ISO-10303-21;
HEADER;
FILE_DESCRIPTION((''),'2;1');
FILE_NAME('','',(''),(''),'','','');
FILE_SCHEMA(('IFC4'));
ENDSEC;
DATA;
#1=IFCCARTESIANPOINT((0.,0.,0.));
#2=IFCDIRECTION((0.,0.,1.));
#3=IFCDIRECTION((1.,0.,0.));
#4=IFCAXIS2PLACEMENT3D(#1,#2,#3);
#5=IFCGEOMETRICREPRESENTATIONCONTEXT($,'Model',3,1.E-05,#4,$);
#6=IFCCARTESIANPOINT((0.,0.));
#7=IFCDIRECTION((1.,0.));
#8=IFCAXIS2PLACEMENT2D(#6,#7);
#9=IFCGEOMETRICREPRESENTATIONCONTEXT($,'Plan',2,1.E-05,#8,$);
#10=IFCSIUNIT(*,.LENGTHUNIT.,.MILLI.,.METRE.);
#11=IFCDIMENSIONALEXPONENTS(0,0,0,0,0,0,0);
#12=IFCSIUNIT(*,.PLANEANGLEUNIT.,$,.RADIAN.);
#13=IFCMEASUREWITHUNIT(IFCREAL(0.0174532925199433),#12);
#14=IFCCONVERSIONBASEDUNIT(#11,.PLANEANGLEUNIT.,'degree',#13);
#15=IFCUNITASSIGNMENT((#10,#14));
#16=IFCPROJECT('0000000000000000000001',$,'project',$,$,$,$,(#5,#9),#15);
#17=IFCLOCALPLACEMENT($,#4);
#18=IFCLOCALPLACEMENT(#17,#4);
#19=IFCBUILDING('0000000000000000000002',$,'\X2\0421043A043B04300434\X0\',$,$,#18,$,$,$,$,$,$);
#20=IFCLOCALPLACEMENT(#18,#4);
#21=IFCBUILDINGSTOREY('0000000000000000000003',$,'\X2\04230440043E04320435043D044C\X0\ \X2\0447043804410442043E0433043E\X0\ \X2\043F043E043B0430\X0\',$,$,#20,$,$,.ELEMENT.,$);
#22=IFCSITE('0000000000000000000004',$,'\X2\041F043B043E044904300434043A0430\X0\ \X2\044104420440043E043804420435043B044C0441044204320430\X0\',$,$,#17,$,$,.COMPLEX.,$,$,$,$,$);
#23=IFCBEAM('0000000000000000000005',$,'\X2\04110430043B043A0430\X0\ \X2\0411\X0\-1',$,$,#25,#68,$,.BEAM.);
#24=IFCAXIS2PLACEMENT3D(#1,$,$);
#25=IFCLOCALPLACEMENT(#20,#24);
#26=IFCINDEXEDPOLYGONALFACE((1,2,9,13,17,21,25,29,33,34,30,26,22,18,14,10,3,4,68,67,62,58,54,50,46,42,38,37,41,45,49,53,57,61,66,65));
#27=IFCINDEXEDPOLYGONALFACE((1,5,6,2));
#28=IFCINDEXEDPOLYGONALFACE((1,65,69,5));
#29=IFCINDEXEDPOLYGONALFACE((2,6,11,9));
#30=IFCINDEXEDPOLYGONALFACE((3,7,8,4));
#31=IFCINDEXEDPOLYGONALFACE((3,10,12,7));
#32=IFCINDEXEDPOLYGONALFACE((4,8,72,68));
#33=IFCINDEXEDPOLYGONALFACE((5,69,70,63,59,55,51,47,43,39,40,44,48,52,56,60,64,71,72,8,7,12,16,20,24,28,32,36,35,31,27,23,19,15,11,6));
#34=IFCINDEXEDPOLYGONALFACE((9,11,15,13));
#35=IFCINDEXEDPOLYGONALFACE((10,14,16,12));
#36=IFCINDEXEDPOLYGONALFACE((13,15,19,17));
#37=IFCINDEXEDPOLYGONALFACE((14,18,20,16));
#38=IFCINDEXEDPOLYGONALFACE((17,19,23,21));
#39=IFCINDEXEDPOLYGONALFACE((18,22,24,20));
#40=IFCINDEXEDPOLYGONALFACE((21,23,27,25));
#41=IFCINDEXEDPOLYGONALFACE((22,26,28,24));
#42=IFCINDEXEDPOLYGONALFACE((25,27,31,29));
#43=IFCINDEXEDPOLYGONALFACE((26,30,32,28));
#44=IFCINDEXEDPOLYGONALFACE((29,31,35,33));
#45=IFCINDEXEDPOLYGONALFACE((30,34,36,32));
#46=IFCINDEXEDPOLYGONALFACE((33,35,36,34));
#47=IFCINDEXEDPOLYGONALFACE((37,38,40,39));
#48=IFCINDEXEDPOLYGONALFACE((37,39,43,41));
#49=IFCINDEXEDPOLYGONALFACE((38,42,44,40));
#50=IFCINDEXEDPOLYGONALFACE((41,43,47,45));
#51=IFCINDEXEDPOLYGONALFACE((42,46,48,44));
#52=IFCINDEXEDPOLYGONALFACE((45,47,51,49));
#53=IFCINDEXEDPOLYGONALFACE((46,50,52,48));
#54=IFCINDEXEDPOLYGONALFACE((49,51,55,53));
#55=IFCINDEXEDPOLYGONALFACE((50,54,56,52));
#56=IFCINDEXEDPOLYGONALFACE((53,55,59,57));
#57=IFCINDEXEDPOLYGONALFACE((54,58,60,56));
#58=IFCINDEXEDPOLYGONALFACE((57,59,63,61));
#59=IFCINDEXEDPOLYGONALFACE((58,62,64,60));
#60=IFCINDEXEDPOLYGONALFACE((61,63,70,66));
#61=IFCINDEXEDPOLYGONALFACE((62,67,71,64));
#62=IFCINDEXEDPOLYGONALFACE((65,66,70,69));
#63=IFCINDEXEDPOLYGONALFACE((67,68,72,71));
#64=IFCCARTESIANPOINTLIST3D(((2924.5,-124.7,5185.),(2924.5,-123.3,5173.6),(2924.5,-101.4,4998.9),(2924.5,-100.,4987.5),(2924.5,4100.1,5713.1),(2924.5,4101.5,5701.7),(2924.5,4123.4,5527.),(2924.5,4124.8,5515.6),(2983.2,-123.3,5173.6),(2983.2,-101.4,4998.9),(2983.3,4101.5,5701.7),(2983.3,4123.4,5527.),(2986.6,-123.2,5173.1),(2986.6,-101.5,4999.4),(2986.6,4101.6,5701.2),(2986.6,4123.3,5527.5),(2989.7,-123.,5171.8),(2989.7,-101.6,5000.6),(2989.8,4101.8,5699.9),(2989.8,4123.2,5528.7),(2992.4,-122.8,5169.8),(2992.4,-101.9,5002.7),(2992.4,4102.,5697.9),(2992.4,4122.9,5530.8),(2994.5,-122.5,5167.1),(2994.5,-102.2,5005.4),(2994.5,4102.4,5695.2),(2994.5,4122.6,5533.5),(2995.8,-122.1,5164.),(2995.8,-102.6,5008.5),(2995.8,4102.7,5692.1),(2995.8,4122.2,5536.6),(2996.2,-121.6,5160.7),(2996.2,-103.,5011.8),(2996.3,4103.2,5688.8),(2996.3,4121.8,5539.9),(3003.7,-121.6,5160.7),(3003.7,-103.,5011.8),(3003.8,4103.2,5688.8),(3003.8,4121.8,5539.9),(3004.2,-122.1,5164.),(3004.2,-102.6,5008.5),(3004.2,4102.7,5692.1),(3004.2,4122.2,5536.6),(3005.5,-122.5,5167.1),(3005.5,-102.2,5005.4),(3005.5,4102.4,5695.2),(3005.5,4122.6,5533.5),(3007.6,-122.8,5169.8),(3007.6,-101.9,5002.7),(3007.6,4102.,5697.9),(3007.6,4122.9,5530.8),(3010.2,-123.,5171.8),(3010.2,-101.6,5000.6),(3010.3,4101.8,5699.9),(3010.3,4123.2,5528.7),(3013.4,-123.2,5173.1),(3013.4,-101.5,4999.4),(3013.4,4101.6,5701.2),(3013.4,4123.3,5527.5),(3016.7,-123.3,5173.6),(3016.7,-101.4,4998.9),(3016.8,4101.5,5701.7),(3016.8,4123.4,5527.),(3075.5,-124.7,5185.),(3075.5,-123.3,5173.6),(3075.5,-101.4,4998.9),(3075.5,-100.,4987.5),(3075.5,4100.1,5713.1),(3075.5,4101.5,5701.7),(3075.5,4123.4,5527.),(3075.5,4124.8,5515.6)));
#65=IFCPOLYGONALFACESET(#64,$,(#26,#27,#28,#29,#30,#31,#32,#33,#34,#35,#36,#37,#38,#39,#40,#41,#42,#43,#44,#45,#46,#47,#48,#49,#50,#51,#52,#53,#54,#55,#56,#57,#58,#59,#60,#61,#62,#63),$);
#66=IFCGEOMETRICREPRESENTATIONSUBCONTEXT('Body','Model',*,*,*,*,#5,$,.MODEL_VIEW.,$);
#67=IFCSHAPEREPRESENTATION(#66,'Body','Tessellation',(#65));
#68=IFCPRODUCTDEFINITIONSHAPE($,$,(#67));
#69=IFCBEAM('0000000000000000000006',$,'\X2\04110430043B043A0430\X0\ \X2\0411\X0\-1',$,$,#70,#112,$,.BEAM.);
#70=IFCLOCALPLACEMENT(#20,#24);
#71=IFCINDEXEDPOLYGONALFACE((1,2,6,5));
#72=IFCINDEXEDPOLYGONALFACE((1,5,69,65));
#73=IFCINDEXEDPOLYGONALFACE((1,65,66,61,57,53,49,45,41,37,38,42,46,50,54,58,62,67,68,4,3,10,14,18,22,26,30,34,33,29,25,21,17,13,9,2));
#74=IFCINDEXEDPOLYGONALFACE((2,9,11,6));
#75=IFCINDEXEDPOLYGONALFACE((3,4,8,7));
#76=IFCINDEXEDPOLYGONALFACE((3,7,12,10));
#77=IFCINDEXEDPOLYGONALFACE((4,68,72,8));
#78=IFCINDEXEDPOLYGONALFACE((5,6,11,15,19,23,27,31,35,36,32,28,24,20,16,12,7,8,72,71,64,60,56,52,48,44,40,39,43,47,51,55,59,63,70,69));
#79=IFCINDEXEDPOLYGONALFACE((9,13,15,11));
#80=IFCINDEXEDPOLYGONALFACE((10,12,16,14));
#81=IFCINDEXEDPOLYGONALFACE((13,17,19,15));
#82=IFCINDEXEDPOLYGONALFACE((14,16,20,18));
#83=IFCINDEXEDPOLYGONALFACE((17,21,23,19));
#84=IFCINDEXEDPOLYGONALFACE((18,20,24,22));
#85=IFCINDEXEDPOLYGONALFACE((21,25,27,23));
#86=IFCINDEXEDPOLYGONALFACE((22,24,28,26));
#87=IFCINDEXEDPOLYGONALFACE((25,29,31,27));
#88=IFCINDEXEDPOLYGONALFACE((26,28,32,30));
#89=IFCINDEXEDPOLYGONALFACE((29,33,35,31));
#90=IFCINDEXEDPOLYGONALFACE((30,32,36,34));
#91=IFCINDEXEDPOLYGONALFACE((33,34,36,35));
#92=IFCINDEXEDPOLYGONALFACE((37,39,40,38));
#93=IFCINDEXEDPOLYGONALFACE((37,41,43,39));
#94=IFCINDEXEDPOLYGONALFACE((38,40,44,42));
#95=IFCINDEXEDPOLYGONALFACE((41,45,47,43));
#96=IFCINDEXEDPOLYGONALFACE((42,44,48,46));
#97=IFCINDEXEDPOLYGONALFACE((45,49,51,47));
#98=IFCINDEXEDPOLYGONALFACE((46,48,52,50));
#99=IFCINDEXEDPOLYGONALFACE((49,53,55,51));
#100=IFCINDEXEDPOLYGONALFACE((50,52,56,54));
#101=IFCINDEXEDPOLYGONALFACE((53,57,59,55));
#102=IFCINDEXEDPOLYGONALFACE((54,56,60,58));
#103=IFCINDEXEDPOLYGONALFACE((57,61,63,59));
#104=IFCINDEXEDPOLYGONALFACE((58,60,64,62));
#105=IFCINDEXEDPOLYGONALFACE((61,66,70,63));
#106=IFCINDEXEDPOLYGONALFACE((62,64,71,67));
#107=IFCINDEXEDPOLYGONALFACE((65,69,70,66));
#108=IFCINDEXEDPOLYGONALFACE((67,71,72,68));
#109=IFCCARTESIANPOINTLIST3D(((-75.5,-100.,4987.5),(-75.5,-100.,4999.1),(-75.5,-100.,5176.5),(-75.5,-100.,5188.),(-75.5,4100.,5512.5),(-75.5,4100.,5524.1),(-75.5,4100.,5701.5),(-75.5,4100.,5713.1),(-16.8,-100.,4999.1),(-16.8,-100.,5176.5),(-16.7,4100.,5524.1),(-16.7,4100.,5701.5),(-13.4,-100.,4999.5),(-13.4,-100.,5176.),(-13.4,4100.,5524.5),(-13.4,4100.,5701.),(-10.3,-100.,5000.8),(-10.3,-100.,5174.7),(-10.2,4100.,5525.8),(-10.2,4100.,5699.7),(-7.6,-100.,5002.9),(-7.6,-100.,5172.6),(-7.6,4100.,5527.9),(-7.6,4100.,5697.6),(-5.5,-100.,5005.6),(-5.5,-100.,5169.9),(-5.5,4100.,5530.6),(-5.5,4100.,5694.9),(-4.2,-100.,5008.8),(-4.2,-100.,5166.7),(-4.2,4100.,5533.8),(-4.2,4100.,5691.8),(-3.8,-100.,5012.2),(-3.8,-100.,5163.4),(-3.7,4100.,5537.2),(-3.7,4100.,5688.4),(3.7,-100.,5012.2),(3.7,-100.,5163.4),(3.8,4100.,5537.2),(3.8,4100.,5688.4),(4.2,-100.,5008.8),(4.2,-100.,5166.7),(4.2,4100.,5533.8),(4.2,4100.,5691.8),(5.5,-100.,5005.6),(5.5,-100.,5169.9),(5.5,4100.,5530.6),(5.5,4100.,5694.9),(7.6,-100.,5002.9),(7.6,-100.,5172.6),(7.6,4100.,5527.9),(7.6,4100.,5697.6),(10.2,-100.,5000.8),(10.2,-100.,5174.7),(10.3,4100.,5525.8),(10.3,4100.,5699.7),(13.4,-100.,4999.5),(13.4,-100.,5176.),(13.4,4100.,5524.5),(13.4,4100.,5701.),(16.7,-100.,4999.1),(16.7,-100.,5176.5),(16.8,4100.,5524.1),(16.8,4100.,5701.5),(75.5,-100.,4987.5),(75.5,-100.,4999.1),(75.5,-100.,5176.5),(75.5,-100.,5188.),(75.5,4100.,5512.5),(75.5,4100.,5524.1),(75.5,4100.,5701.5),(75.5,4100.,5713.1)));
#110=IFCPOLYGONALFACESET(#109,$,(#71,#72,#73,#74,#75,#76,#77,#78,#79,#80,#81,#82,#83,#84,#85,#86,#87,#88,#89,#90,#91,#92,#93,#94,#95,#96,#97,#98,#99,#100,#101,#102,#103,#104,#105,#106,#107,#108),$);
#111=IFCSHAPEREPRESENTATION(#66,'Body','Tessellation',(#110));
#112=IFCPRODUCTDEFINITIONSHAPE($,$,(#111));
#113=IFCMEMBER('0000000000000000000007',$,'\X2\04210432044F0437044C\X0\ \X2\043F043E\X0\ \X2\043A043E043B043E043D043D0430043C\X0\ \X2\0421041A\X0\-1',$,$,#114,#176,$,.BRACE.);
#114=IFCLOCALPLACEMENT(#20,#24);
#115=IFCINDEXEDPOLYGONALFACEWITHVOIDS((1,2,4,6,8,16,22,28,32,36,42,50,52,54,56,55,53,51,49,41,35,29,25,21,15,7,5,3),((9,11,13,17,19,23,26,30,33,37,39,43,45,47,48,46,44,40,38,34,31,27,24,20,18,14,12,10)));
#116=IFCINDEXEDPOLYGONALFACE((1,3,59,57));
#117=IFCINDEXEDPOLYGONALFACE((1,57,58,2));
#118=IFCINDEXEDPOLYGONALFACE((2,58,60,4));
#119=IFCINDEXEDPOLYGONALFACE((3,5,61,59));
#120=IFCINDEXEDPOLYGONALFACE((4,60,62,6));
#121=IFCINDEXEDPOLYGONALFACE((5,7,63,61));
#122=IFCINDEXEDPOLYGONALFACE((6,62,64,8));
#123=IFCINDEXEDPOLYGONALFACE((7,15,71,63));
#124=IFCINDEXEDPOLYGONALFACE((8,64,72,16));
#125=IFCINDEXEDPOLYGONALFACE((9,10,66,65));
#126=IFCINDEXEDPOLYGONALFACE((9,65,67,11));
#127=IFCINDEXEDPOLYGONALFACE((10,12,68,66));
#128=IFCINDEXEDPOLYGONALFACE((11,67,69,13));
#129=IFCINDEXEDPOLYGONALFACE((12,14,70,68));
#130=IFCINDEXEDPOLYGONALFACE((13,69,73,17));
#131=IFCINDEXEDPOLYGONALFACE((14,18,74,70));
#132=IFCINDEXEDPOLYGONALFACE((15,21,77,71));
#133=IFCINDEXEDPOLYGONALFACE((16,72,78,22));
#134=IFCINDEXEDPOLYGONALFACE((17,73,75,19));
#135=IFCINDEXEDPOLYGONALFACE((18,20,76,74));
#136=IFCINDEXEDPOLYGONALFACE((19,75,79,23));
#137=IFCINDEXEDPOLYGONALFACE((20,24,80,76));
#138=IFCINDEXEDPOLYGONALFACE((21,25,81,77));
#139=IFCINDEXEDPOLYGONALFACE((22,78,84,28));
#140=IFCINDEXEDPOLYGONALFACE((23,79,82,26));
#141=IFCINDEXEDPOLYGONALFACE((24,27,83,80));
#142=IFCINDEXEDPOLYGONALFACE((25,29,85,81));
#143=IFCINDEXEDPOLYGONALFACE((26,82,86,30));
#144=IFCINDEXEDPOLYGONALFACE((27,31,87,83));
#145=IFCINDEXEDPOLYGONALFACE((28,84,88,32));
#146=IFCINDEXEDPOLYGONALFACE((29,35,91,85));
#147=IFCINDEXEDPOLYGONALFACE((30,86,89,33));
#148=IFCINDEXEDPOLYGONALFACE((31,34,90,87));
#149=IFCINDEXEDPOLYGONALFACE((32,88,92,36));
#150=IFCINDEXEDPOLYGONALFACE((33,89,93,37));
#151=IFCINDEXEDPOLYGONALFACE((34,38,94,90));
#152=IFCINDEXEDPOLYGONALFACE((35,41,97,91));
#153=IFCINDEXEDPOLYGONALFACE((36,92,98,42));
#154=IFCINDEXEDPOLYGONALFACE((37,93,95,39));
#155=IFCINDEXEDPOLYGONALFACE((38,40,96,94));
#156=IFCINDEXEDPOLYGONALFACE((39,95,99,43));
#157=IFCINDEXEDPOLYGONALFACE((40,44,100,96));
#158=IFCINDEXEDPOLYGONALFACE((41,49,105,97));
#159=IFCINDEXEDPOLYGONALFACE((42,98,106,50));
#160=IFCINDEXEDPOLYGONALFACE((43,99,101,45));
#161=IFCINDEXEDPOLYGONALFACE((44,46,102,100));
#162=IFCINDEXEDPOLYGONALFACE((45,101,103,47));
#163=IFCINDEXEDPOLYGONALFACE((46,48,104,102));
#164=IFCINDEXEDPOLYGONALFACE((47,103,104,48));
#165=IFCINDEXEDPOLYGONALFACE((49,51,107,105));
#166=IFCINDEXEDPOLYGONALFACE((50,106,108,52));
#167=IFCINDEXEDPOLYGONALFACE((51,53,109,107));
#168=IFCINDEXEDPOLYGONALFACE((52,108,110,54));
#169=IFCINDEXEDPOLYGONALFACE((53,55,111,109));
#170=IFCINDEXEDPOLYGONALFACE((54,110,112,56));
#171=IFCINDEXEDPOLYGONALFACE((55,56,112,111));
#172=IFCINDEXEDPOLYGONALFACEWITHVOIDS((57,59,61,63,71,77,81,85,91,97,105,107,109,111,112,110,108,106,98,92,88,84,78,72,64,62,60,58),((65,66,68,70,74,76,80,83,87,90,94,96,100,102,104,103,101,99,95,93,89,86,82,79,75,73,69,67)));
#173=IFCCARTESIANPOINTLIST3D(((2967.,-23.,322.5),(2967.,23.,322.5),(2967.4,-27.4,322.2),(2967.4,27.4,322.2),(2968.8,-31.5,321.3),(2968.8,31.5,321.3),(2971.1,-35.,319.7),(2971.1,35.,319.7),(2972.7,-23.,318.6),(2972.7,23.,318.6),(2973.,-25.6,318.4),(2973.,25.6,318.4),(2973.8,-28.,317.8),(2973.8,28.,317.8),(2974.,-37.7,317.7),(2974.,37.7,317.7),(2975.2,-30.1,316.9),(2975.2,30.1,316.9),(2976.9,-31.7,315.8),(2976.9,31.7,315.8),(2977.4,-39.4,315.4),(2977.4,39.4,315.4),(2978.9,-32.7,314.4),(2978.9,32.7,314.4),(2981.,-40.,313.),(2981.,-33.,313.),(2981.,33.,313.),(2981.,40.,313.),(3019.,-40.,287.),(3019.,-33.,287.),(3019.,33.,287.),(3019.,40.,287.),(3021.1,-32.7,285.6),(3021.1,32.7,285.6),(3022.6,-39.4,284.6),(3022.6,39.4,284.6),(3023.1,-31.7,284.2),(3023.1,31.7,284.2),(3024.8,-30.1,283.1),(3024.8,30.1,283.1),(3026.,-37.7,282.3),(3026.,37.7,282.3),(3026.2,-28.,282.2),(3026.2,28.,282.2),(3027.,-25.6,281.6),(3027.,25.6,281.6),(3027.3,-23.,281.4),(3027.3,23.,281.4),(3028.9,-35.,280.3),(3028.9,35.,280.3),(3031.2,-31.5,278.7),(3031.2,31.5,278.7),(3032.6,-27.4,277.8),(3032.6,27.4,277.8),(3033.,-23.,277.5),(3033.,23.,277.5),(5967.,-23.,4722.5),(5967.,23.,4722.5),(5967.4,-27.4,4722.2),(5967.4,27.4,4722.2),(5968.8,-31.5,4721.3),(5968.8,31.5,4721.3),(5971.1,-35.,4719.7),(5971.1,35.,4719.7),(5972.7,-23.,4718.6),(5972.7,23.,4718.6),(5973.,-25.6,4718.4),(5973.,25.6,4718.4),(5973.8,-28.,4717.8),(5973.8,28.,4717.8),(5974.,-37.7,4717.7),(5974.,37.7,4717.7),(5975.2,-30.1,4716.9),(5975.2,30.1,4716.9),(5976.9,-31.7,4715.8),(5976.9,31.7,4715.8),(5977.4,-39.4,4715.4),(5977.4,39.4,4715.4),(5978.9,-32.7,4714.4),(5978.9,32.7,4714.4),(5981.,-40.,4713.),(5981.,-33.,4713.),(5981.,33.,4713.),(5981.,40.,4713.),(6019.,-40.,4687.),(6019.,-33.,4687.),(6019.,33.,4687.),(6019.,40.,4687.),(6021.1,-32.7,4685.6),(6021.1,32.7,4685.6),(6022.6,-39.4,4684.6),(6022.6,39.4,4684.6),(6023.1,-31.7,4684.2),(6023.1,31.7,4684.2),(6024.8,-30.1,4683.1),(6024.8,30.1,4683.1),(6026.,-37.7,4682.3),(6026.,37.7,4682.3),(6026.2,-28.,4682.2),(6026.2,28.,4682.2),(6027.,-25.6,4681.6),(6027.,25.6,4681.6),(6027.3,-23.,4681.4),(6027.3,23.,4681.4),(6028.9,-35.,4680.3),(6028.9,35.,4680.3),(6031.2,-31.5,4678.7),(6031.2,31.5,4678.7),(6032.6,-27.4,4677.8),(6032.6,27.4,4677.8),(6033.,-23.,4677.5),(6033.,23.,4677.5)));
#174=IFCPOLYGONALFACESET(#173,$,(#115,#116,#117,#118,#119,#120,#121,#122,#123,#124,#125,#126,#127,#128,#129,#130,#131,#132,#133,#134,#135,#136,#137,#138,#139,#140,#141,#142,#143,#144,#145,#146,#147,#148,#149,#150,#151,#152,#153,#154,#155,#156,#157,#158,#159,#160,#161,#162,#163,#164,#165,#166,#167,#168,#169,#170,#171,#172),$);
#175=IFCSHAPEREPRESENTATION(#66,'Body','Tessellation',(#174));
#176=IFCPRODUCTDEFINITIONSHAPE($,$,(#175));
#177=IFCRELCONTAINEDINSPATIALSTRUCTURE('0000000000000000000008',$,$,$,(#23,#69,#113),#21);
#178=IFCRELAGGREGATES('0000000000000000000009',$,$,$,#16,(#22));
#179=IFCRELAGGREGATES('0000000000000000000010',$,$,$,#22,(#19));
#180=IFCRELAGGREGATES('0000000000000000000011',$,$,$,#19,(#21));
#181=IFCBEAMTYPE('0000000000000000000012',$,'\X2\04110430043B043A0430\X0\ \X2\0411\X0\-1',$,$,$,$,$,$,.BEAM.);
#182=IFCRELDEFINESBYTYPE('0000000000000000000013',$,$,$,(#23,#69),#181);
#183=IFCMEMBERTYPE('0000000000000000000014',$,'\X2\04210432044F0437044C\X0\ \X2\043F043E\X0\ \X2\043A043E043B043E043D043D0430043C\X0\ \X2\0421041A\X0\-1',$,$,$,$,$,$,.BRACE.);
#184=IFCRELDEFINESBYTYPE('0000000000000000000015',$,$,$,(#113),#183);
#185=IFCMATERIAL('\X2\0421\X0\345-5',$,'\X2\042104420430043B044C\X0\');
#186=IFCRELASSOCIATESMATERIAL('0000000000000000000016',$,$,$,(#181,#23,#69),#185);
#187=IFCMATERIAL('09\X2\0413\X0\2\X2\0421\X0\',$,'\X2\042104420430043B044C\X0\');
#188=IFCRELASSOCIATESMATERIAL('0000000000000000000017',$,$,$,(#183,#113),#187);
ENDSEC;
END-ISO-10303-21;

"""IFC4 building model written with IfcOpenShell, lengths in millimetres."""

from ifc_helpers import new_model, entity, si_unit, converted_unit, frame, origin_with_axes, origin_2d_with_axis, place, context, subcontext, project, spatial, hollow_rectangle, i_section, extrude, clip, halfspace, material, material_profile, profile_set, profile_usage, type_object, element, save


model = new_model("IFC4")

# Units and contexts
model_context = context("Model", 3, precision=1e-05, world=origin_with_axes())
plan_context = context("Plan", 2, precision=1e-05, world=origin_2d_with_axis())
body_context = subcontext(model_context, "Body", "Model", "MODEL_VIEW")
ifc_project = project(units=[si_unit("LENGTHUNIT", "METRE", prefix="MILLI"), converted_unit("PLANEANGLEUNIT", "degree", entity("IfcReal", 0.0174532925199433), si_unit("PLANEANGLEUNIT", "RADIAN"), dimensions=[0, 0, 0, 0, 0, 0, 0])], contexts=[model_context, plan_context])

# Site, building, storey
site_placement = place(None, origin_with_axes())
site = spatial("IfcSite", under=ifc_project, at=site_placement, Name="Площадка строительства", CompositionType="COMPLEX")
building_placement = place(site_placement, origin_with_axes())
building = spatial("IfcBuilding", under=site, at=building_placement, Name="Склад")
storey_placement = place(building_placement, origin_with_axes())
storey = spatial("IfcBuildingStorey", under=building, at=storey_placement, Name="Уровень чистого пола", CompositionType="ELEMENT")

# Shared definitions
ifc_material_1 = material(Name="С345-5", Category="Сталь")

# Beams
ifc_material_profile_1 = material_profile(ifc_material_1, i_section(OverallWidth=151.0, OverallDepth=199.0, WebThickness=7.5, FlangeThickness=11.5, FilletRadius=13.0, FlangeEdgeRadius=0.0, FlangeSlope=0.0))
ifc_profile_set_1 = profile_set([ifc_material_profile_1], Name="I20H2_S345-5")
ifc_profile_usage_1 = profile_usage(ifc_profile_set_1, cardinal=2)
beam_type_1 = type_object("IfcBeamType", Name="Балка Б-1", PredefinedType="BEAM", material=ifc_profile_set_1)
beam_1_placement = place(storey_placement, frame((3000.0, -100.0, 4987.5), z_axis=(0.0, 0.992278, 0.124035), x_axis=(-1.0, 0.0, 0.0)))
element("IfcBeam", 1, at=beam_1_placement, inside=storey, type_object=beam_type_1, material=ifc_profile_usage_1, Name="Балка Б-1", PredefinedType="BEAM", context=body_context, shape_type="SweptSolid", body=[
    extrude(i_section(OverallWidth=151.0, OverallDepth=199.0, WebThickness=7.5, FlangeThickness=11.5, FilletRadius=13.0, FlangeEdgeRadius=0.0, FlangeSlope=0.0), frame((0.0, 99.5, 0.0), z_axis=(0.0, 0.0, 1.0), x_axis=(1.0, 0.0, 0.0)), (0.0, 0.0, 1.0), 4257.7),
])
beam_2_placement = place(storey_placement, frame((0.0, -298.5, 4962.7), z_axis=(0.0, 0.992278, 0.124035), x_axis=(-1.0, 0.0, 0.0)))
element("IfcBeam", 2, at=beam_2_placement, inside=storey, type_object=beam_type_1, material=ifc_profile_usage_1, Name="Балка Б-1", PredefinedType="BEAM", context=body_context, shape_type="Clipping", body=[
    clip(clip(extrude(i_section(OverallWidth=151.0, OverallDepth=199.0, WebThickness=7.5, FlangeThickness=11.5, FilletRadius=13.0, FlangeEdgeRadius=0.0, FlangeSlope=0.0), frame((0.0, 99.5, 0.0), z_axis=(0.0, 0.0, 1.0), x_axis=(1.0, 0.0, 0.0)), (0.0, 0.0, 1.0), 4632.7), halfspace(frame((0.0, -5469.9, 3748.9), z_axis=(0.0, -0.124035, 0.992278), x_axis=(0.0, 0.992278, 0.124035)), False)), halfspace(frame((0.0, -4949.0, -418.6), z_axis=(0.0, 0.124035, -0.992278), x_axis=(0.0, 0.992278, 0.124035)), False)),
])

# Member
ifc_material_2 = material(Name="09Г2С", Category="Сталь")
ifc_material_profile_2 = material_profile(ifc_material_2, hollow_rectangle(XDim=80.0, YDim=80.0, WallThickness=7.0, InnerFilletRadius=10.0, OuterFilletRadius=17.0))
ifc_profile_set_2 = profile_set([ifc_material_profile_2], Name="PK80x7_09G2S")
ifc_profile_usage_2 = profile_usage(ifc_profile_set_2, cardinal=5)
member_type_1 = type_object("IfcMemberType", Name="Связь по колоннам СК-1", PredefinedType="BRACE", material=ifc_profile_set_2)
member_1_placement = place(storey_placement, frame((3000.0, 0.0, 300.0), z_axis=(0.563337, 0.0, 0.826227), x_axis=(0.0, 1.0, 0.0)))
element("IfcMember", 3, at=member_1_placement, inside=storey, type_object=member_type_1, material=ifc_profile_usage_2, Name="Связь по колоннам СК-1", PredefinedType="BRACE", context=body_context, shape_type="Clipping", body=[
    extrude(hollow_rectangle(XDim=80.0, YDim=80.0, WallThickness=7.0, InnerFilletRadius=10.0, OuterFilletRadius=17.0), origin_with_axes(), (0.0, 0.0, 1.0), 5325.4),
])

save(model, "model.ifc")
